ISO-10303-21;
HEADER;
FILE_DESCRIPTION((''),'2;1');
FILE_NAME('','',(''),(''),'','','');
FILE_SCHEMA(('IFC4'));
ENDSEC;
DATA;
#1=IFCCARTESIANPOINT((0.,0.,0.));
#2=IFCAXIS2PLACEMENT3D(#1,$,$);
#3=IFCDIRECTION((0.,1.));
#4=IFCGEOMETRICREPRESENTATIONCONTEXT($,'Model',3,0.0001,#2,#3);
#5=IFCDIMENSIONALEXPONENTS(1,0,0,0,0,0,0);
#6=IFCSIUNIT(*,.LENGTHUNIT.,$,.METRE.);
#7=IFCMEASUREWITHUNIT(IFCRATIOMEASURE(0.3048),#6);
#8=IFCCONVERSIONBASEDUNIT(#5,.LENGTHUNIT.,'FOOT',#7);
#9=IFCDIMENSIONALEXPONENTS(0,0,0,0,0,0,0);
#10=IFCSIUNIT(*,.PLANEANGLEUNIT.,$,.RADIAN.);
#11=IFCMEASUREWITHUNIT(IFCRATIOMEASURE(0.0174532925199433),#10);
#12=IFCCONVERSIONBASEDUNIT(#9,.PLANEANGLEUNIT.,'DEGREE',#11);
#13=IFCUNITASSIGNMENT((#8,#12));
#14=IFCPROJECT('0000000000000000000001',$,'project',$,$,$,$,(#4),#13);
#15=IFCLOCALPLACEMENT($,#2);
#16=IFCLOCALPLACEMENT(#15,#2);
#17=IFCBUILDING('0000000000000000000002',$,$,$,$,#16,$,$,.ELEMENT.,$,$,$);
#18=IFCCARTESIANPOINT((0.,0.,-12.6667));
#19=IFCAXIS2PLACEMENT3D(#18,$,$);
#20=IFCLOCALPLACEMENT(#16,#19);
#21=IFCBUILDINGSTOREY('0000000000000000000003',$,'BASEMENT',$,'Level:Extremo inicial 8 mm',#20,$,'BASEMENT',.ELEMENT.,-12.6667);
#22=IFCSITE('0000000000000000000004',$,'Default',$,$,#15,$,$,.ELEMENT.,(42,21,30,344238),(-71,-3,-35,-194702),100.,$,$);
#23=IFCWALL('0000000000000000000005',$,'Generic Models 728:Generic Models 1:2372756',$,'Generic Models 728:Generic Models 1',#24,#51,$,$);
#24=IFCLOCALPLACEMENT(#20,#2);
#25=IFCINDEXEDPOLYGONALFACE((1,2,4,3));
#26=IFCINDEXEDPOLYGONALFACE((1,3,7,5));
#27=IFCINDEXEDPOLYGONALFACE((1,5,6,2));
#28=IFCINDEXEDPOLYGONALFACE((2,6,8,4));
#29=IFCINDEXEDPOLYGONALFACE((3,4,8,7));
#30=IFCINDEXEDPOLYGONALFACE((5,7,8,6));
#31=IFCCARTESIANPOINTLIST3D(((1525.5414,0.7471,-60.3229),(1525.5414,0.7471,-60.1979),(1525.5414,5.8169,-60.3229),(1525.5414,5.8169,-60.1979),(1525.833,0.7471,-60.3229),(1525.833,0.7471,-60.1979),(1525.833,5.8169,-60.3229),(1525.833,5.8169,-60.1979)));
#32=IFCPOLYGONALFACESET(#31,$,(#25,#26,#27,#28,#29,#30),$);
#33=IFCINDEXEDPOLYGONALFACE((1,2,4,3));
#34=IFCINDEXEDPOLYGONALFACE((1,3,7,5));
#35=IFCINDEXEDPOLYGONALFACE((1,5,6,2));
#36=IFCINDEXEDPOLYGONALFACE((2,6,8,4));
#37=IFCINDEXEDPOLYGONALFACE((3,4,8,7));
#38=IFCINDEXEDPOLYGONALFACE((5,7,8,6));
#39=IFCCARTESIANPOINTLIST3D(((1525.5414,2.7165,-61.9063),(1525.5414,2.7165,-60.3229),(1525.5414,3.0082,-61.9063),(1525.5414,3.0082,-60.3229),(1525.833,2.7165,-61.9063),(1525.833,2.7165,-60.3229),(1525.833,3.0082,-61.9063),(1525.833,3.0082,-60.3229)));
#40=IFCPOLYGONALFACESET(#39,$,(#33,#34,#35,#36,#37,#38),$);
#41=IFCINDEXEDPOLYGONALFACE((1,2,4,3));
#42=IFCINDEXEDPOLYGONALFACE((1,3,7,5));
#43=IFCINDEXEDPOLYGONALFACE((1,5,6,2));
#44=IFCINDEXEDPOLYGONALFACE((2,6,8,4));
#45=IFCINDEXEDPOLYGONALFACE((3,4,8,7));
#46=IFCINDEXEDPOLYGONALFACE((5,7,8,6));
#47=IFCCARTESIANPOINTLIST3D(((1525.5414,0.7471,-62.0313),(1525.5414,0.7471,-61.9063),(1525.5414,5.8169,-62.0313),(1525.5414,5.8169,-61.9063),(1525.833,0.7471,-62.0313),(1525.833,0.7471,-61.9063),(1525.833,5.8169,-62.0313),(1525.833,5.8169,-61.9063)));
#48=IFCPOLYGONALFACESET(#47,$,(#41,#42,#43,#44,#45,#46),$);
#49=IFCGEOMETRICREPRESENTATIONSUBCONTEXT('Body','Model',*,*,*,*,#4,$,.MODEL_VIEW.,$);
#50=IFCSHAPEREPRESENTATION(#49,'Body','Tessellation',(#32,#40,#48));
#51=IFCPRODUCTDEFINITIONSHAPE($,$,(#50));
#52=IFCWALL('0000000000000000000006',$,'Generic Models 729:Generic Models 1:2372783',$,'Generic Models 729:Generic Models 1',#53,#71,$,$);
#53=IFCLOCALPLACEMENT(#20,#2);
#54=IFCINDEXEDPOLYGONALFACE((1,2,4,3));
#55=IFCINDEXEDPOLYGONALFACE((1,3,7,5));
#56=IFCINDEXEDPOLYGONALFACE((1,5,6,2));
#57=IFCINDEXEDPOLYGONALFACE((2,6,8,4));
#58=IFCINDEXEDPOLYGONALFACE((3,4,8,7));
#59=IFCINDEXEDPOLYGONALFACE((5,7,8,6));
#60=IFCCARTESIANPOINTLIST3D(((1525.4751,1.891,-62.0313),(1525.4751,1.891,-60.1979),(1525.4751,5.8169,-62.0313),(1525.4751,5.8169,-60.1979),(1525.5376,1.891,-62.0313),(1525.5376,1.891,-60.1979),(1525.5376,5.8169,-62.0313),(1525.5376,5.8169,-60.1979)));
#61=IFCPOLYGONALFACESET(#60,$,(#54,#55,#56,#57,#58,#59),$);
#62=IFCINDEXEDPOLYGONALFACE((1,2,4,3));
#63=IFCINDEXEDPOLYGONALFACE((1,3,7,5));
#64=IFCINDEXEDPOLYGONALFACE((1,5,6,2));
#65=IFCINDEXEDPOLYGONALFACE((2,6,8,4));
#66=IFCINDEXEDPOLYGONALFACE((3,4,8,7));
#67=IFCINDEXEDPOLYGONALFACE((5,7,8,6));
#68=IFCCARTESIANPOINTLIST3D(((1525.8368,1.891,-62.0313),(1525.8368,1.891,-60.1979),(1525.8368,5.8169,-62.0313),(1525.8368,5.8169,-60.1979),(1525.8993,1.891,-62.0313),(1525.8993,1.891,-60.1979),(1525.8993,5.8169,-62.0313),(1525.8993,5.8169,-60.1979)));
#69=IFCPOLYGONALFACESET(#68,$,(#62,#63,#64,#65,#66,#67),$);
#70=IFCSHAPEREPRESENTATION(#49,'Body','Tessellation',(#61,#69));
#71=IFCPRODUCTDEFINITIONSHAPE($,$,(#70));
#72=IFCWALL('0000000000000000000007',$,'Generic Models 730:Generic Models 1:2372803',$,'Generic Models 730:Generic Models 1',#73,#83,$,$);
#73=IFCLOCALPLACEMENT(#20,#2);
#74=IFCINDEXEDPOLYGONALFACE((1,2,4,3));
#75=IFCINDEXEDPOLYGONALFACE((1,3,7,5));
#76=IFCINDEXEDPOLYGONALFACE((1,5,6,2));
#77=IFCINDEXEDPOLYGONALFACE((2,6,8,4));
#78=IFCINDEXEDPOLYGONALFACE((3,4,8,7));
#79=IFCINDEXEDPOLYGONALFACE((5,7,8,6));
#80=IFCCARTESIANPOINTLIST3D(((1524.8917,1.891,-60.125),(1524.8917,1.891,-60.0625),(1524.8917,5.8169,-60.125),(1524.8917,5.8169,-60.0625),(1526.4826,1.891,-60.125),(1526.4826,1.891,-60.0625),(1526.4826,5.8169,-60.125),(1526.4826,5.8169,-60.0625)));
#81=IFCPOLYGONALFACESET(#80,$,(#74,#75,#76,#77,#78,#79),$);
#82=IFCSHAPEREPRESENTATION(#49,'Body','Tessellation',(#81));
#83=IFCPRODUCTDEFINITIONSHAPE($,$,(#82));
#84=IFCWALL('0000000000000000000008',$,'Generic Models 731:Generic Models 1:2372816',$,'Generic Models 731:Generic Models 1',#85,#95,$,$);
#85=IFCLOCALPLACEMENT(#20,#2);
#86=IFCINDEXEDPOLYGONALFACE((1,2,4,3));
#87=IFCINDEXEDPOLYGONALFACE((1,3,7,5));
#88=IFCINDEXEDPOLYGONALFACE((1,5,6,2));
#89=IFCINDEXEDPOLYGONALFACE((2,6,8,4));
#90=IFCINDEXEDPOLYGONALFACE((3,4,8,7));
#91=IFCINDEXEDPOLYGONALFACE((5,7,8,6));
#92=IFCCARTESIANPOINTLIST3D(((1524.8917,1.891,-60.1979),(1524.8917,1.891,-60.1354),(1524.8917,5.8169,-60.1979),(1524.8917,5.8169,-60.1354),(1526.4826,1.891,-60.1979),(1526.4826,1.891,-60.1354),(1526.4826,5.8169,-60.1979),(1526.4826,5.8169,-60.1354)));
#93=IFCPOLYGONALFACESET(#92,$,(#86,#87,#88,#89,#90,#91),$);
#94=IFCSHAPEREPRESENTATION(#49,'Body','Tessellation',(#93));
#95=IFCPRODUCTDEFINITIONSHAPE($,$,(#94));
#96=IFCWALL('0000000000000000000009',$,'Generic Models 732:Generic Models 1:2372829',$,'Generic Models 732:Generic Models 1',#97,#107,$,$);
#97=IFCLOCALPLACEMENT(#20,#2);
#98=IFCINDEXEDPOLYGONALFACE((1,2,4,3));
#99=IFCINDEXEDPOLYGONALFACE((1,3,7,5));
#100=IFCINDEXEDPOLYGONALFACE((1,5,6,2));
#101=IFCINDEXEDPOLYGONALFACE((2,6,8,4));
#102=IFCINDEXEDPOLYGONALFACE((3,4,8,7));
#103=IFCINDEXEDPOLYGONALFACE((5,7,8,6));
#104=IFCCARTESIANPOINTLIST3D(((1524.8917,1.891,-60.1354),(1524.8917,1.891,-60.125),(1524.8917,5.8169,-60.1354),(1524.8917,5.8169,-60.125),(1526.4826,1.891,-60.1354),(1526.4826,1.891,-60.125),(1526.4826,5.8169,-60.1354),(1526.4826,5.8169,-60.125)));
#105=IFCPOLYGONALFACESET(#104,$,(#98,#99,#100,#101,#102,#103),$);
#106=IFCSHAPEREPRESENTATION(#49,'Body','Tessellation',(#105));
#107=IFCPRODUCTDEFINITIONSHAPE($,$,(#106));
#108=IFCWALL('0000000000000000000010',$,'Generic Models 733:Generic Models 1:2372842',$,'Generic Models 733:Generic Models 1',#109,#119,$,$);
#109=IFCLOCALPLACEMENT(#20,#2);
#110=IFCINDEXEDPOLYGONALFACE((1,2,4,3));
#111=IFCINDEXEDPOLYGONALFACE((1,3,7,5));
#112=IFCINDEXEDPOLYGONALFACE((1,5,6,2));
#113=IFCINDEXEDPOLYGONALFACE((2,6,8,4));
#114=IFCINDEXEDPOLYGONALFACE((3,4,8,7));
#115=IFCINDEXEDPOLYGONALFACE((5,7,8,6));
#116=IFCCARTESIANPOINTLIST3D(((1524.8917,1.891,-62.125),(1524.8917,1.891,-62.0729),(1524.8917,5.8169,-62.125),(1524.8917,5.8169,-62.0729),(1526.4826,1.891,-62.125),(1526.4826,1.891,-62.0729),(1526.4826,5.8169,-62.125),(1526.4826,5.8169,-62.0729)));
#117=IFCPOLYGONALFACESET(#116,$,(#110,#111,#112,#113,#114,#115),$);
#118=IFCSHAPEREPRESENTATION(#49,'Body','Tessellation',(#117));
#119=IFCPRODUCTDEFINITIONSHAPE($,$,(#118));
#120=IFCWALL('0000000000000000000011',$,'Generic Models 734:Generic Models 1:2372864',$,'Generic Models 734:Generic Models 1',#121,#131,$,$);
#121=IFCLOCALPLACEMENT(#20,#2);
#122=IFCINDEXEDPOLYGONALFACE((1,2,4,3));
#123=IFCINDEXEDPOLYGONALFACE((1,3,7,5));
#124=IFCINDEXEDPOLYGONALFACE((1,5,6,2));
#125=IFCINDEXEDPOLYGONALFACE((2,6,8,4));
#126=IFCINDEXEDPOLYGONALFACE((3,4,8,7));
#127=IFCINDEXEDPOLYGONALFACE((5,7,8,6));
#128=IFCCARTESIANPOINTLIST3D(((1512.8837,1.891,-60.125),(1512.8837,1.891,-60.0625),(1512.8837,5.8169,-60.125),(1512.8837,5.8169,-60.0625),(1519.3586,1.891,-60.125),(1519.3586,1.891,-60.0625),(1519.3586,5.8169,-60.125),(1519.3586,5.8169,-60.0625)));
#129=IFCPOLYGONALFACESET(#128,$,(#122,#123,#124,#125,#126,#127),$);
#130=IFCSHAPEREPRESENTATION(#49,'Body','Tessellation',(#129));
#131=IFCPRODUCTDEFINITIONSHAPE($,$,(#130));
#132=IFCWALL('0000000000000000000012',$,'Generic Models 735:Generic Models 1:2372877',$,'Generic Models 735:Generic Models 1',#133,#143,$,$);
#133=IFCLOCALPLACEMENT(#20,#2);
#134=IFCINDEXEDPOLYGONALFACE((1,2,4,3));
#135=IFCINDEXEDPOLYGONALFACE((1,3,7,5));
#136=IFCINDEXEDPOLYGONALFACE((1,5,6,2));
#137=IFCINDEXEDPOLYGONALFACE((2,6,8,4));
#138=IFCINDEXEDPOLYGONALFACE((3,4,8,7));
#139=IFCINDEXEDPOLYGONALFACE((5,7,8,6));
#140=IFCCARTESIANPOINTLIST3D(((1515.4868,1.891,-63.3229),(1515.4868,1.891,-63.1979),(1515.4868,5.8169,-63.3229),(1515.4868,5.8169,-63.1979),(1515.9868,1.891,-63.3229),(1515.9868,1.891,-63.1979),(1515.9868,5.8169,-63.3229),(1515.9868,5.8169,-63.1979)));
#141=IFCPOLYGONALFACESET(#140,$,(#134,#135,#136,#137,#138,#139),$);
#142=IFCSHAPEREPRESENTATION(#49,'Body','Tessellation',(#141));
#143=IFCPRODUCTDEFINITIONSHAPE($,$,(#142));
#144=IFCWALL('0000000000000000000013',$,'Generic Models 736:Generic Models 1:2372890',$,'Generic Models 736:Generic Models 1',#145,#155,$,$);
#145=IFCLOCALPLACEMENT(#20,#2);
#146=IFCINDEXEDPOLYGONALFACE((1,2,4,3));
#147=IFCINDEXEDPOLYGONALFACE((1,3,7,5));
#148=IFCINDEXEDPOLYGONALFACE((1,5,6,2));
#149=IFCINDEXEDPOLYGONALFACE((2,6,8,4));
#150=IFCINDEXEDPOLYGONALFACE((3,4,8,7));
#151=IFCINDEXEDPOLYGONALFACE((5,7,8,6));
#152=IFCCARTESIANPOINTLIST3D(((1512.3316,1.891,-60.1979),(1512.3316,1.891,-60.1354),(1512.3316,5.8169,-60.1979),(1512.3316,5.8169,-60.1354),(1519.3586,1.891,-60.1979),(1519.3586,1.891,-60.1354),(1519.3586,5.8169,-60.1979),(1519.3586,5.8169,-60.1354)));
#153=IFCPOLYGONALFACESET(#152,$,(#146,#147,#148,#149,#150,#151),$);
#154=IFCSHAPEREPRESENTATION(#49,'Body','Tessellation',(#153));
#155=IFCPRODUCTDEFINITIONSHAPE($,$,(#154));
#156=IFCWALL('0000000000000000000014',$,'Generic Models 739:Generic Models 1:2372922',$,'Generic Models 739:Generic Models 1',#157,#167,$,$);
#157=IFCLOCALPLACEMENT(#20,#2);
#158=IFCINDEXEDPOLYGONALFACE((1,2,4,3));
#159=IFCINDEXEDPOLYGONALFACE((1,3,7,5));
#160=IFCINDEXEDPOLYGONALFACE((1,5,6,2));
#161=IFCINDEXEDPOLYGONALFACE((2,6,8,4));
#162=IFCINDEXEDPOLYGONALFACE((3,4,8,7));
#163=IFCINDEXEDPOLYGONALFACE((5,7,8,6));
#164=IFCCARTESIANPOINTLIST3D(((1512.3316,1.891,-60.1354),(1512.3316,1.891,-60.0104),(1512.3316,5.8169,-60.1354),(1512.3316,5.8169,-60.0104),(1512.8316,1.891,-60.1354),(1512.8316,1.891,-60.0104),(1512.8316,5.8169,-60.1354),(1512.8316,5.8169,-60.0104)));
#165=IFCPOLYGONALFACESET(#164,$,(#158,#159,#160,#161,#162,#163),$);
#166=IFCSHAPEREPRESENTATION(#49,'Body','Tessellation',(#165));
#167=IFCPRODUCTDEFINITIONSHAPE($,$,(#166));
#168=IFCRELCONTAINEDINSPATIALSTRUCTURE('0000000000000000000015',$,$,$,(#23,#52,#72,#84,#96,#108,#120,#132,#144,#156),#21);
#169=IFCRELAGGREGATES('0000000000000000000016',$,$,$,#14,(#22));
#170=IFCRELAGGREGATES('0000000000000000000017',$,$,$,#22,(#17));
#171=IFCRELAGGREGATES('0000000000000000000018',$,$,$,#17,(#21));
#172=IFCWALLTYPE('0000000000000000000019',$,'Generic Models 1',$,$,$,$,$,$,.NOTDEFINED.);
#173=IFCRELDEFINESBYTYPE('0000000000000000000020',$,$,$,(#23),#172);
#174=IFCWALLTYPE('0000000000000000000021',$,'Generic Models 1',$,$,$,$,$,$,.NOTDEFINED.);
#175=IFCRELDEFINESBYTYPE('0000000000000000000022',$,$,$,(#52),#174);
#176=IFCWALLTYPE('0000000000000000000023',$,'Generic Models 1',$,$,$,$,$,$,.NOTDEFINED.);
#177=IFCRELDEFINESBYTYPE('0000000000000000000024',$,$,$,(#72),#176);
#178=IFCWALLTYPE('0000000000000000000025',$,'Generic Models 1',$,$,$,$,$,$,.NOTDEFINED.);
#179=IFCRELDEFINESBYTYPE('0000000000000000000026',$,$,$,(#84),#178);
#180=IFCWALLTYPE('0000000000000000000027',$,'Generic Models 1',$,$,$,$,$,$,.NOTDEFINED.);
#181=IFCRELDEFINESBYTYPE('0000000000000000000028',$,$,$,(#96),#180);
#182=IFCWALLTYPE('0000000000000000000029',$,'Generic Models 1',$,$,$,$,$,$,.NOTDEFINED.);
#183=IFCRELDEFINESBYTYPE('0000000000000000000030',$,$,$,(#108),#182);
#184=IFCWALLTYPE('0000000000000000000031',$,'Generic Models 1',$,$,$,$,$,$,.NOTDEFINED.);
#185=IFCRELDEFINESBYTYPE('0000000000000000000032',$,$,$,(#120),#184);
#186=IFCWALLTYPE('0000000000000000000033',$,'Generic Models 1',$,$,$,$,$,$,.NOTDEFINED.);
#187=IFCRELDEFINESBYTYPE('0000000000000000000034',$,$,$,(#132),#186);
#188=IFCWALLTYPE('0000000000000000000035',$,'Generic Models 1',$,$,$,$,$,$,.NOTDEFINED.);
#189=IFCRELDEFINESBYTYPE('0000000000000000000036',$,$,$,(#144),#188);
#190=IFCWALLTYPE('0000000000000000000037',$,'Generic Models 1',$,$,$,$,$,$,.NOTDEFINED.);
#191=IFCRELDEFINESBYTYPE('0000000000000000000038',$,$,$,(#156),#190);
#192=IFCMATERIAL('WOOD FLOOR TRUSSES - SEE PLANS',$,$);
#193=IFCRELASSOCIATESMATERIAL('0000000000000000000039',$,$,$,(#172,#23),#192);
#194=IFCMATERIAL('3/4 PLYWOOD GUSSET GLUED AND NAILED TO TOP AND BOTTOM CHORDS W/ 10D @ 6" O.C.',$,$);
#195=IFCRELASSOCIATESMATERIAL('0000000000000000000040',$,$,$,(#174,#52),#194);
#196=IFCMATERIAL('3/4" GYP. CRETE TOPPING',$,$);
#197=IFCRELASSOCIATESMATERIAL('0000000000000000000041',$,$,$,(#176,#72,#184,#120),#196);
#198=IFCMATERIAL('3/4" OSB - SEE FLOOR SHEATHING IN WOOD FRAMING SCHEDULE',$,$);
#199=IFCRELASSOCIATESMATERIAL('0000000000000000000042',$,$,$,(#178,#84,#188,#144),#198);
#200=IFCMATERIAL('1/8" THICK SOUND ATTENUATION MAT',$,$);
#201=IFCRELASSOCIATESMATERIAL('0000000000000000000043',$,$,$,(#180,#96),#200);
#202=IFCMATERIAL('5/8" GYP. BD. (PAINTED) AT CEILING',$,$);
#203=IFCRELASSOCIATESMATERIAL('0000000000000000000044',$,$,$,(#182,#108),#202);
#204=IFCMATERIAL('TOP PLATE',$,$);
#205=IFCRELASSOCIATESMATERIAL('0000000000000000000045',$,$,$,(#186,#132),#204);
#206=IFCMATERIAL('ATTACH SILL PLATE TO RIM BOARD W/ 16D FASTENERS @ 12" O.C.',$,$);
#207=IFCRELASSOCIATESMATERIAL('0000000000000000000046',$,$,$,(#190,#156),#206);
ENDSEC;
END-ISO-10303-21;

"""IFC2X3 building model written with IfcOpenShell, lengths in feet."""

from ifc_helpers import new_model, entity, si_unit, converted_unit, direction, frame, frame_2d, origin, origin_2d_with_axis, place, context, subcontext, project, spatial, rectangle, extrude, material, type_object, element, save


model = new_model("IFC2X3")

# Units and contexts
model_context = context("Model", 3, precision=0.0001, world=origin(), true_north=direction((0.0, 1.0)))
body_context = subcontext(model_context, "Body", "Model", "MODEL_VIEW")
ifc_project = project(units=[converted_unit("LENGTHUNIT", "FOOT", entity("IfcRatioMeasure", 0.3048), si_unit("LENGTHUNIT", "METRE"), dimensions=[1, 0, 0, 0, 0, 0, 0]), converted_unit("PLANEANGLEUNIT", "DEGREE", entity("IfcRatioMeasure", 0.0174532925199433), si_unit("PLANEANGLEUNIT", "RADIAN"), dimensions=[0, 0, 0, 0, 0, 0, 0])], contexts=[model_context])

# Site, building, storey
site_placement = place(None, origin())
site = spatial("IfcSite", under=ifc_project, at=site_placement, Name="Default", CompositionType="ELEMENT", RefLatitude=(42, 21, 30, 344238), RefLongitude=(-71, -3, -35, -194702), RefElevation=100.0)
building_placement = place(site_placement, origin())
building = spatial("IfcBuilding", under=site, at=building_placement, CompositionType="ELEMENT")
storey_placement = place(building_placement, frame((0.0, 0.0, -12.6667)))
storey = spatial("IfcBuildingStorey", under=building, at=storey_placement, Name="BASEMENT", ObjectType="Level:Extremo inicial 8 mm", LongName="BASEMENT", CompositionType="ELEMENT", Elevation=-12.6667)

# Walls
ifc_material_1 = material(Name="WOOD FLOOR TRUSSES - SEE PLANS")
wall_type_1 = type_object("IfcWallType", Name="Generic Models 1", PredefinedType="NOTDEFINED", material=ifc_material_1)
wall_1_placement = place(storey_placement, frame((1525.5414, 0.7471, -62.0313), z_axis=(0.0, 0.0, 1.0), x_axis=(0.0, 1.0, 0.0)))
element("IfcWall", 1, at=wall_1_placement, inside=storey, type_object=wall_type_1, material=ifc_material_1, Name="Generic Models 728:Generic Models 1:2372756", ObjectType="Generic Models 728:Generic Models 1", context=body_context, shape_type="SweptSolid", body=[
    extrude(rectangle(XDim=5.0697, YDim=0.2917, at=frame_2d((0.0, 0.0), x_axis=(1.0, 0.0))), frame((2.5349, -0.1458, 1.7083)), (0.0, 0.0, 1.0), 0.125),
    extrude(rectangle(XDim=0.2917, YDim=0.2917, at=frame_2d((0.0, 0.0), x_axis=(1.0, 0.0))), frame((2.1152, -0.1458, 0.125)), (0.0, 0.0, 1.0), 1.5833),
    extrude(rectangle(XDim=5.0697, YDim=0.2917, at=frame_2d((0.0, 0.0), x_axis=(1.0, 0.0))), frame((2.5349, -0.1458, 0.0)), (0.0, 0.0, 1.0), 0.125),
])
ifc_material_2 = material(Name="3/4 PLYWOOD GUSSET GLUED AND NAILED TO TOP AND BOTTOM CHORDS W/ 10D @ 6\" O.C.")
wall_type_2 = type_object("IfcWallType", Name="Generic Models 1", PredefinedType="NOTDEFINED", material=ifc_material_2)
wall_2_placement = place(storey_placement, frame((1525.4751, 1.891, -62.0313), z_axis=(0.0, 0.0, 1.0), x_axis=(0.0, 1.0, 0.0)))
element("IfcWall", 2, at=wall_2_placement, inside=storey, type_object=wall_type_2, material=ifc_material_2, Name="Generic Models 729:Generic Models 1:2372783", ObjectType="Generic Models 729:Generic Models 1", context=body_context, shape_type="SweptSolid", body=[
    extrude(rectangle(XDim=3.9258, YDim=0.0625, at=frame_2d((0.0, 0.0), x_axis=(1.0, 0.0))), frame((1.9629, -0.0312, 0.0)), (0.0, 0.0, 1.0), 1.8333),
    extrude(rectangle(XDim=3.9258, YDim=0.0625, at=frame_2d((0.0, 0.0), x_axis=(1.0, 0.0))), frame((1.9629, -0.393, 0.0)), (0.0, 0.0, 1.0), 1.8333),
])
ifc_material_3 = material(Name="3/4\" GYP. CRETE TOPPING")
wall_type_3 = type_object("IfcWallType", Name="Generic Models 1", PredefinedType="NOTDEFINED", material=ifc_material_3)
wall_3_placement = place(storey_placement, frame((1524.8917, 1.891, -60.125), z_axis=(0.0, 0.0, 1.0), x_axis=(0.0, 1.0, 0.0)))
element("IfcWall", 3, at=wall_3_placement, inside=storey, type_object=wall_type_3, material=ifc_material_3, Name="Generic Models 730:Generic Models 1:2372803", ObjectType="Generic Models 730:Generic Models 1", context=body_context, shape_type="SweptSolid", body=[
    extrude(rectangle(XDim=3.9258, YDim=1.5909, at=origin_2d_with_axis()), frame((1.9629, -0.7955, 0.0)), (0.0, 0.0, 1.0), 0.0625),
])
ifc_material_4 = material(Name="3/4\" OSB - SEE FLOOR SHEATHING IN WOOD FRAMING SCHEDULE")
wall_type_4 = type_object("IfcWallType", Name="Generic Models 1", PredefinedType="NOTDEFINED", material=ifc_material_4)
wall_4_placement = place(storey_placement, frame((1524.8917, 1.891, -60.1979), z_axis=(0.0, 0.0, 1.0), x_axis=(0.0, 1.0, 0.0)))
element("IfcWall", 4, at=wall_4_placement, inside=storey, type_object=wall_type_4, material=ifc_material_4, Name="Generic Models 731:Generic Models 1:2372816", ObjectType="Generic Models 731:Generic Models 1", context=body_context, shape_type="SweptSolid", body=[
    extrude(rectangle(XDim=3.9258, YDim=1.5909, at=frame_2d((0.0, 0.0), x_axis=(1.0, 0.0))), frame((1.9629, -0.7955, 0.0)), (0.0, 0.0, 1.0), 0.0625),
])
ifc_material_5 = material(Name="1/8\" THICK SOUND ATTENUATION MAT")
wall_type_5 = type_object("IfcWallType", Name="Generic Models 1", PredefinedType="NOTDEFINED", material=ifc_material_5)
wall_5_placement = place(storey_placement, frame((1524.8917, 1.891, -60.1354), z_axis=(0.0, 0.0, 1.0), x_axis=(0.0, 1.0, 0.0)))
element("IfcWall", 5, at=wall_5_placement, inside=storey, type_object=wall_type_5, material=ifc_material_5, Name="Generic Models 732:Generic Models 1:2372829", ObjectType="Generic Models 732:Generic Models 1", context=body_context, shape_type="SweptSolid", body=[
    extrude(rectangle(XDim=3.9258, YDim=1.5909, at=origin_2d_with_axis()), frame((1.9629, -0.7955, 0.0)), (0.0, 0.0, 1.0), 0.0104),
])
ifc_material_6 = material(Name="5/8\" GYP. BD. (PAINTED) AT CEILING")
wall_type_6 = type_object("IfcWallType", Name="Generic Models 1", PredefinedType="NOTDEFINED", material=ifc_material_6)
wall_6_placement = place(storey_placement, frame((1524.8917, 1.891, -62.125), z_axis=(0.0, 0.0, 1.0), x_axis=(0.0, 1.0, 0.0)))
element("IfcWall", 6, at=wall_6_placement, inside=storey, type_object=wall_type_6, material=ifc_material_6, Name="Generic Models 733:Generic Models 1:2372842", ObjectType="Generic Models 733:Generic Models 1", context=body_context, shape_type="SweptSolid", body=[
    extrude(rectangle(XDim=3.9258, YDim=1.5909, at=frame_2d((0.0, 0.0), x_axis=(1.0, 0.0))), frame((1.9629, -0.7955, 0.0)), (0.0, 0.0, 1.0), 0.0521),
])
wall_type_7 = type_object("IfcWallType", Name="Generic Models 1", PredefinedType="NOTDEFINED", material=ifc_material_3)
wall_7_placement = place(storey_placement, frame((1512.8837, 1.891, -60.125)))
element("IfcWall", 7, at=wall_7_placement, inside=storey, type_object=wall_type_7, material=ifc_material_3, Name="Generic Models 734:Generic Models 1:2372864", ObjectType="Generic Models 734:Generic Models 1", context=body_context, shape_type="SweptSolid", body=[
    extrude(rectangle(XDim=3.9258, YDim=6.4749, at=origin_2d_with_axis()), frame((3.2374, 1.9629, 0.0), z_axis=(0.0, 0.0, 1.0), x_axis=(0.0, 1.0, 0.0)), (0.0, 0.0, 1.0), 0.0625),
])
ifc_material_7 = material(Name="TOP PLATE")
wall_type_8 = type_object("IfcWallType", Name="Generic Models 1", PredefinedType="NOTDEFINED", material=ifc_material_7)
wall_8_placement = place(storey_placement, frame((1515.4868, 1.891, -63.3229), z_axis=(0.0, 0.0, 1.0), x_axis=(0.0, 1.0, 0.0)))
element("IfcWall", 8, at=wall_8_placement, inside=storey, type_object=wall_type_8, material=ifc_material_7, Name="Generic Models 735:Generic Models 1:2372877", ObjectType="Generic Models 735:Generic Models 1", context=body_context, shape_type="SweptSolid", body=[
    extrude(rectangle(XDim=3.9258, YDim=0.5, at=frame_2d((0.0, 0.0), x_axis=(1.0, 0.0))), frame((1.9629, -0.25, 0.0)), (0.0, 0.0, 1.0), 0.125),
])
wall_type_9 = type_object("IfcWallType", Name="Generic Models 1", PredefinedType="NOTDEFINED", material=ifc_material_4)
wall_9_placement = place(storey_placement, frame((1512.3316, 1.891, -60.1979)))
element("IfcWall", 9, at=wall_9_placement, inside=storey, type_object=wall_type_9, material=ifc_material_4, Name="Generic Models 736:Generic Models 1:2372890", ObjectType="Generic Models 736:Generic Models 1", context=body_context, shape_type="SweptSolid", body=[
    extrude(rectangle(XDim=3.9258, YDim=7.027, at=frame_2d((0.0, 0.0), x_axis=(1.0, 0.0))), frame((3.5135, 1.9629, 0.0), z_axis=(0.0, 0.0, 1.0), x_axis=(0.0, 1.0, 0.0)), (0.0, 0.0, 1.0), 0.0625),
])
ifc_material_8 = material(Name="ATTACH SILL PLATE TO RIM BOARD W/ 16D FASTENERS @ 12\" O.C.")
wall_type_10 = type_object("IfcWallType", Name="Generic Models 1", PredefinedType="NOTDEFINED", material=ifc_material_8)
wall_10_placement = place(storey_placement, frame((1512.3316, 1.891, -60.1354), z_axis=(0.0, 0.0, 1.0), x_axis=(0.0, 1.0, 0.0)))
element("IfcWall", 10, at=wall_10_placement, inside=storey, type_object=wall_type_10, material=ifc_material_8, Name="Generic Models 739:Generic Models 1:2372922", ObjectType="Generic Models 739:Generic Models 1", context=body_context, shape_type="SweptSolid", body=[
    extrude(rectangle(XDim=3.9258, YDim=0.5, at=frame_2d((0.0, 0.0), x_axis=(1.0, 0.0))), frame((1.9629, -0.25, 0.0)), (0.0, 0.0, 1.0), 0.125),
])

save(model, "model.ifc")
